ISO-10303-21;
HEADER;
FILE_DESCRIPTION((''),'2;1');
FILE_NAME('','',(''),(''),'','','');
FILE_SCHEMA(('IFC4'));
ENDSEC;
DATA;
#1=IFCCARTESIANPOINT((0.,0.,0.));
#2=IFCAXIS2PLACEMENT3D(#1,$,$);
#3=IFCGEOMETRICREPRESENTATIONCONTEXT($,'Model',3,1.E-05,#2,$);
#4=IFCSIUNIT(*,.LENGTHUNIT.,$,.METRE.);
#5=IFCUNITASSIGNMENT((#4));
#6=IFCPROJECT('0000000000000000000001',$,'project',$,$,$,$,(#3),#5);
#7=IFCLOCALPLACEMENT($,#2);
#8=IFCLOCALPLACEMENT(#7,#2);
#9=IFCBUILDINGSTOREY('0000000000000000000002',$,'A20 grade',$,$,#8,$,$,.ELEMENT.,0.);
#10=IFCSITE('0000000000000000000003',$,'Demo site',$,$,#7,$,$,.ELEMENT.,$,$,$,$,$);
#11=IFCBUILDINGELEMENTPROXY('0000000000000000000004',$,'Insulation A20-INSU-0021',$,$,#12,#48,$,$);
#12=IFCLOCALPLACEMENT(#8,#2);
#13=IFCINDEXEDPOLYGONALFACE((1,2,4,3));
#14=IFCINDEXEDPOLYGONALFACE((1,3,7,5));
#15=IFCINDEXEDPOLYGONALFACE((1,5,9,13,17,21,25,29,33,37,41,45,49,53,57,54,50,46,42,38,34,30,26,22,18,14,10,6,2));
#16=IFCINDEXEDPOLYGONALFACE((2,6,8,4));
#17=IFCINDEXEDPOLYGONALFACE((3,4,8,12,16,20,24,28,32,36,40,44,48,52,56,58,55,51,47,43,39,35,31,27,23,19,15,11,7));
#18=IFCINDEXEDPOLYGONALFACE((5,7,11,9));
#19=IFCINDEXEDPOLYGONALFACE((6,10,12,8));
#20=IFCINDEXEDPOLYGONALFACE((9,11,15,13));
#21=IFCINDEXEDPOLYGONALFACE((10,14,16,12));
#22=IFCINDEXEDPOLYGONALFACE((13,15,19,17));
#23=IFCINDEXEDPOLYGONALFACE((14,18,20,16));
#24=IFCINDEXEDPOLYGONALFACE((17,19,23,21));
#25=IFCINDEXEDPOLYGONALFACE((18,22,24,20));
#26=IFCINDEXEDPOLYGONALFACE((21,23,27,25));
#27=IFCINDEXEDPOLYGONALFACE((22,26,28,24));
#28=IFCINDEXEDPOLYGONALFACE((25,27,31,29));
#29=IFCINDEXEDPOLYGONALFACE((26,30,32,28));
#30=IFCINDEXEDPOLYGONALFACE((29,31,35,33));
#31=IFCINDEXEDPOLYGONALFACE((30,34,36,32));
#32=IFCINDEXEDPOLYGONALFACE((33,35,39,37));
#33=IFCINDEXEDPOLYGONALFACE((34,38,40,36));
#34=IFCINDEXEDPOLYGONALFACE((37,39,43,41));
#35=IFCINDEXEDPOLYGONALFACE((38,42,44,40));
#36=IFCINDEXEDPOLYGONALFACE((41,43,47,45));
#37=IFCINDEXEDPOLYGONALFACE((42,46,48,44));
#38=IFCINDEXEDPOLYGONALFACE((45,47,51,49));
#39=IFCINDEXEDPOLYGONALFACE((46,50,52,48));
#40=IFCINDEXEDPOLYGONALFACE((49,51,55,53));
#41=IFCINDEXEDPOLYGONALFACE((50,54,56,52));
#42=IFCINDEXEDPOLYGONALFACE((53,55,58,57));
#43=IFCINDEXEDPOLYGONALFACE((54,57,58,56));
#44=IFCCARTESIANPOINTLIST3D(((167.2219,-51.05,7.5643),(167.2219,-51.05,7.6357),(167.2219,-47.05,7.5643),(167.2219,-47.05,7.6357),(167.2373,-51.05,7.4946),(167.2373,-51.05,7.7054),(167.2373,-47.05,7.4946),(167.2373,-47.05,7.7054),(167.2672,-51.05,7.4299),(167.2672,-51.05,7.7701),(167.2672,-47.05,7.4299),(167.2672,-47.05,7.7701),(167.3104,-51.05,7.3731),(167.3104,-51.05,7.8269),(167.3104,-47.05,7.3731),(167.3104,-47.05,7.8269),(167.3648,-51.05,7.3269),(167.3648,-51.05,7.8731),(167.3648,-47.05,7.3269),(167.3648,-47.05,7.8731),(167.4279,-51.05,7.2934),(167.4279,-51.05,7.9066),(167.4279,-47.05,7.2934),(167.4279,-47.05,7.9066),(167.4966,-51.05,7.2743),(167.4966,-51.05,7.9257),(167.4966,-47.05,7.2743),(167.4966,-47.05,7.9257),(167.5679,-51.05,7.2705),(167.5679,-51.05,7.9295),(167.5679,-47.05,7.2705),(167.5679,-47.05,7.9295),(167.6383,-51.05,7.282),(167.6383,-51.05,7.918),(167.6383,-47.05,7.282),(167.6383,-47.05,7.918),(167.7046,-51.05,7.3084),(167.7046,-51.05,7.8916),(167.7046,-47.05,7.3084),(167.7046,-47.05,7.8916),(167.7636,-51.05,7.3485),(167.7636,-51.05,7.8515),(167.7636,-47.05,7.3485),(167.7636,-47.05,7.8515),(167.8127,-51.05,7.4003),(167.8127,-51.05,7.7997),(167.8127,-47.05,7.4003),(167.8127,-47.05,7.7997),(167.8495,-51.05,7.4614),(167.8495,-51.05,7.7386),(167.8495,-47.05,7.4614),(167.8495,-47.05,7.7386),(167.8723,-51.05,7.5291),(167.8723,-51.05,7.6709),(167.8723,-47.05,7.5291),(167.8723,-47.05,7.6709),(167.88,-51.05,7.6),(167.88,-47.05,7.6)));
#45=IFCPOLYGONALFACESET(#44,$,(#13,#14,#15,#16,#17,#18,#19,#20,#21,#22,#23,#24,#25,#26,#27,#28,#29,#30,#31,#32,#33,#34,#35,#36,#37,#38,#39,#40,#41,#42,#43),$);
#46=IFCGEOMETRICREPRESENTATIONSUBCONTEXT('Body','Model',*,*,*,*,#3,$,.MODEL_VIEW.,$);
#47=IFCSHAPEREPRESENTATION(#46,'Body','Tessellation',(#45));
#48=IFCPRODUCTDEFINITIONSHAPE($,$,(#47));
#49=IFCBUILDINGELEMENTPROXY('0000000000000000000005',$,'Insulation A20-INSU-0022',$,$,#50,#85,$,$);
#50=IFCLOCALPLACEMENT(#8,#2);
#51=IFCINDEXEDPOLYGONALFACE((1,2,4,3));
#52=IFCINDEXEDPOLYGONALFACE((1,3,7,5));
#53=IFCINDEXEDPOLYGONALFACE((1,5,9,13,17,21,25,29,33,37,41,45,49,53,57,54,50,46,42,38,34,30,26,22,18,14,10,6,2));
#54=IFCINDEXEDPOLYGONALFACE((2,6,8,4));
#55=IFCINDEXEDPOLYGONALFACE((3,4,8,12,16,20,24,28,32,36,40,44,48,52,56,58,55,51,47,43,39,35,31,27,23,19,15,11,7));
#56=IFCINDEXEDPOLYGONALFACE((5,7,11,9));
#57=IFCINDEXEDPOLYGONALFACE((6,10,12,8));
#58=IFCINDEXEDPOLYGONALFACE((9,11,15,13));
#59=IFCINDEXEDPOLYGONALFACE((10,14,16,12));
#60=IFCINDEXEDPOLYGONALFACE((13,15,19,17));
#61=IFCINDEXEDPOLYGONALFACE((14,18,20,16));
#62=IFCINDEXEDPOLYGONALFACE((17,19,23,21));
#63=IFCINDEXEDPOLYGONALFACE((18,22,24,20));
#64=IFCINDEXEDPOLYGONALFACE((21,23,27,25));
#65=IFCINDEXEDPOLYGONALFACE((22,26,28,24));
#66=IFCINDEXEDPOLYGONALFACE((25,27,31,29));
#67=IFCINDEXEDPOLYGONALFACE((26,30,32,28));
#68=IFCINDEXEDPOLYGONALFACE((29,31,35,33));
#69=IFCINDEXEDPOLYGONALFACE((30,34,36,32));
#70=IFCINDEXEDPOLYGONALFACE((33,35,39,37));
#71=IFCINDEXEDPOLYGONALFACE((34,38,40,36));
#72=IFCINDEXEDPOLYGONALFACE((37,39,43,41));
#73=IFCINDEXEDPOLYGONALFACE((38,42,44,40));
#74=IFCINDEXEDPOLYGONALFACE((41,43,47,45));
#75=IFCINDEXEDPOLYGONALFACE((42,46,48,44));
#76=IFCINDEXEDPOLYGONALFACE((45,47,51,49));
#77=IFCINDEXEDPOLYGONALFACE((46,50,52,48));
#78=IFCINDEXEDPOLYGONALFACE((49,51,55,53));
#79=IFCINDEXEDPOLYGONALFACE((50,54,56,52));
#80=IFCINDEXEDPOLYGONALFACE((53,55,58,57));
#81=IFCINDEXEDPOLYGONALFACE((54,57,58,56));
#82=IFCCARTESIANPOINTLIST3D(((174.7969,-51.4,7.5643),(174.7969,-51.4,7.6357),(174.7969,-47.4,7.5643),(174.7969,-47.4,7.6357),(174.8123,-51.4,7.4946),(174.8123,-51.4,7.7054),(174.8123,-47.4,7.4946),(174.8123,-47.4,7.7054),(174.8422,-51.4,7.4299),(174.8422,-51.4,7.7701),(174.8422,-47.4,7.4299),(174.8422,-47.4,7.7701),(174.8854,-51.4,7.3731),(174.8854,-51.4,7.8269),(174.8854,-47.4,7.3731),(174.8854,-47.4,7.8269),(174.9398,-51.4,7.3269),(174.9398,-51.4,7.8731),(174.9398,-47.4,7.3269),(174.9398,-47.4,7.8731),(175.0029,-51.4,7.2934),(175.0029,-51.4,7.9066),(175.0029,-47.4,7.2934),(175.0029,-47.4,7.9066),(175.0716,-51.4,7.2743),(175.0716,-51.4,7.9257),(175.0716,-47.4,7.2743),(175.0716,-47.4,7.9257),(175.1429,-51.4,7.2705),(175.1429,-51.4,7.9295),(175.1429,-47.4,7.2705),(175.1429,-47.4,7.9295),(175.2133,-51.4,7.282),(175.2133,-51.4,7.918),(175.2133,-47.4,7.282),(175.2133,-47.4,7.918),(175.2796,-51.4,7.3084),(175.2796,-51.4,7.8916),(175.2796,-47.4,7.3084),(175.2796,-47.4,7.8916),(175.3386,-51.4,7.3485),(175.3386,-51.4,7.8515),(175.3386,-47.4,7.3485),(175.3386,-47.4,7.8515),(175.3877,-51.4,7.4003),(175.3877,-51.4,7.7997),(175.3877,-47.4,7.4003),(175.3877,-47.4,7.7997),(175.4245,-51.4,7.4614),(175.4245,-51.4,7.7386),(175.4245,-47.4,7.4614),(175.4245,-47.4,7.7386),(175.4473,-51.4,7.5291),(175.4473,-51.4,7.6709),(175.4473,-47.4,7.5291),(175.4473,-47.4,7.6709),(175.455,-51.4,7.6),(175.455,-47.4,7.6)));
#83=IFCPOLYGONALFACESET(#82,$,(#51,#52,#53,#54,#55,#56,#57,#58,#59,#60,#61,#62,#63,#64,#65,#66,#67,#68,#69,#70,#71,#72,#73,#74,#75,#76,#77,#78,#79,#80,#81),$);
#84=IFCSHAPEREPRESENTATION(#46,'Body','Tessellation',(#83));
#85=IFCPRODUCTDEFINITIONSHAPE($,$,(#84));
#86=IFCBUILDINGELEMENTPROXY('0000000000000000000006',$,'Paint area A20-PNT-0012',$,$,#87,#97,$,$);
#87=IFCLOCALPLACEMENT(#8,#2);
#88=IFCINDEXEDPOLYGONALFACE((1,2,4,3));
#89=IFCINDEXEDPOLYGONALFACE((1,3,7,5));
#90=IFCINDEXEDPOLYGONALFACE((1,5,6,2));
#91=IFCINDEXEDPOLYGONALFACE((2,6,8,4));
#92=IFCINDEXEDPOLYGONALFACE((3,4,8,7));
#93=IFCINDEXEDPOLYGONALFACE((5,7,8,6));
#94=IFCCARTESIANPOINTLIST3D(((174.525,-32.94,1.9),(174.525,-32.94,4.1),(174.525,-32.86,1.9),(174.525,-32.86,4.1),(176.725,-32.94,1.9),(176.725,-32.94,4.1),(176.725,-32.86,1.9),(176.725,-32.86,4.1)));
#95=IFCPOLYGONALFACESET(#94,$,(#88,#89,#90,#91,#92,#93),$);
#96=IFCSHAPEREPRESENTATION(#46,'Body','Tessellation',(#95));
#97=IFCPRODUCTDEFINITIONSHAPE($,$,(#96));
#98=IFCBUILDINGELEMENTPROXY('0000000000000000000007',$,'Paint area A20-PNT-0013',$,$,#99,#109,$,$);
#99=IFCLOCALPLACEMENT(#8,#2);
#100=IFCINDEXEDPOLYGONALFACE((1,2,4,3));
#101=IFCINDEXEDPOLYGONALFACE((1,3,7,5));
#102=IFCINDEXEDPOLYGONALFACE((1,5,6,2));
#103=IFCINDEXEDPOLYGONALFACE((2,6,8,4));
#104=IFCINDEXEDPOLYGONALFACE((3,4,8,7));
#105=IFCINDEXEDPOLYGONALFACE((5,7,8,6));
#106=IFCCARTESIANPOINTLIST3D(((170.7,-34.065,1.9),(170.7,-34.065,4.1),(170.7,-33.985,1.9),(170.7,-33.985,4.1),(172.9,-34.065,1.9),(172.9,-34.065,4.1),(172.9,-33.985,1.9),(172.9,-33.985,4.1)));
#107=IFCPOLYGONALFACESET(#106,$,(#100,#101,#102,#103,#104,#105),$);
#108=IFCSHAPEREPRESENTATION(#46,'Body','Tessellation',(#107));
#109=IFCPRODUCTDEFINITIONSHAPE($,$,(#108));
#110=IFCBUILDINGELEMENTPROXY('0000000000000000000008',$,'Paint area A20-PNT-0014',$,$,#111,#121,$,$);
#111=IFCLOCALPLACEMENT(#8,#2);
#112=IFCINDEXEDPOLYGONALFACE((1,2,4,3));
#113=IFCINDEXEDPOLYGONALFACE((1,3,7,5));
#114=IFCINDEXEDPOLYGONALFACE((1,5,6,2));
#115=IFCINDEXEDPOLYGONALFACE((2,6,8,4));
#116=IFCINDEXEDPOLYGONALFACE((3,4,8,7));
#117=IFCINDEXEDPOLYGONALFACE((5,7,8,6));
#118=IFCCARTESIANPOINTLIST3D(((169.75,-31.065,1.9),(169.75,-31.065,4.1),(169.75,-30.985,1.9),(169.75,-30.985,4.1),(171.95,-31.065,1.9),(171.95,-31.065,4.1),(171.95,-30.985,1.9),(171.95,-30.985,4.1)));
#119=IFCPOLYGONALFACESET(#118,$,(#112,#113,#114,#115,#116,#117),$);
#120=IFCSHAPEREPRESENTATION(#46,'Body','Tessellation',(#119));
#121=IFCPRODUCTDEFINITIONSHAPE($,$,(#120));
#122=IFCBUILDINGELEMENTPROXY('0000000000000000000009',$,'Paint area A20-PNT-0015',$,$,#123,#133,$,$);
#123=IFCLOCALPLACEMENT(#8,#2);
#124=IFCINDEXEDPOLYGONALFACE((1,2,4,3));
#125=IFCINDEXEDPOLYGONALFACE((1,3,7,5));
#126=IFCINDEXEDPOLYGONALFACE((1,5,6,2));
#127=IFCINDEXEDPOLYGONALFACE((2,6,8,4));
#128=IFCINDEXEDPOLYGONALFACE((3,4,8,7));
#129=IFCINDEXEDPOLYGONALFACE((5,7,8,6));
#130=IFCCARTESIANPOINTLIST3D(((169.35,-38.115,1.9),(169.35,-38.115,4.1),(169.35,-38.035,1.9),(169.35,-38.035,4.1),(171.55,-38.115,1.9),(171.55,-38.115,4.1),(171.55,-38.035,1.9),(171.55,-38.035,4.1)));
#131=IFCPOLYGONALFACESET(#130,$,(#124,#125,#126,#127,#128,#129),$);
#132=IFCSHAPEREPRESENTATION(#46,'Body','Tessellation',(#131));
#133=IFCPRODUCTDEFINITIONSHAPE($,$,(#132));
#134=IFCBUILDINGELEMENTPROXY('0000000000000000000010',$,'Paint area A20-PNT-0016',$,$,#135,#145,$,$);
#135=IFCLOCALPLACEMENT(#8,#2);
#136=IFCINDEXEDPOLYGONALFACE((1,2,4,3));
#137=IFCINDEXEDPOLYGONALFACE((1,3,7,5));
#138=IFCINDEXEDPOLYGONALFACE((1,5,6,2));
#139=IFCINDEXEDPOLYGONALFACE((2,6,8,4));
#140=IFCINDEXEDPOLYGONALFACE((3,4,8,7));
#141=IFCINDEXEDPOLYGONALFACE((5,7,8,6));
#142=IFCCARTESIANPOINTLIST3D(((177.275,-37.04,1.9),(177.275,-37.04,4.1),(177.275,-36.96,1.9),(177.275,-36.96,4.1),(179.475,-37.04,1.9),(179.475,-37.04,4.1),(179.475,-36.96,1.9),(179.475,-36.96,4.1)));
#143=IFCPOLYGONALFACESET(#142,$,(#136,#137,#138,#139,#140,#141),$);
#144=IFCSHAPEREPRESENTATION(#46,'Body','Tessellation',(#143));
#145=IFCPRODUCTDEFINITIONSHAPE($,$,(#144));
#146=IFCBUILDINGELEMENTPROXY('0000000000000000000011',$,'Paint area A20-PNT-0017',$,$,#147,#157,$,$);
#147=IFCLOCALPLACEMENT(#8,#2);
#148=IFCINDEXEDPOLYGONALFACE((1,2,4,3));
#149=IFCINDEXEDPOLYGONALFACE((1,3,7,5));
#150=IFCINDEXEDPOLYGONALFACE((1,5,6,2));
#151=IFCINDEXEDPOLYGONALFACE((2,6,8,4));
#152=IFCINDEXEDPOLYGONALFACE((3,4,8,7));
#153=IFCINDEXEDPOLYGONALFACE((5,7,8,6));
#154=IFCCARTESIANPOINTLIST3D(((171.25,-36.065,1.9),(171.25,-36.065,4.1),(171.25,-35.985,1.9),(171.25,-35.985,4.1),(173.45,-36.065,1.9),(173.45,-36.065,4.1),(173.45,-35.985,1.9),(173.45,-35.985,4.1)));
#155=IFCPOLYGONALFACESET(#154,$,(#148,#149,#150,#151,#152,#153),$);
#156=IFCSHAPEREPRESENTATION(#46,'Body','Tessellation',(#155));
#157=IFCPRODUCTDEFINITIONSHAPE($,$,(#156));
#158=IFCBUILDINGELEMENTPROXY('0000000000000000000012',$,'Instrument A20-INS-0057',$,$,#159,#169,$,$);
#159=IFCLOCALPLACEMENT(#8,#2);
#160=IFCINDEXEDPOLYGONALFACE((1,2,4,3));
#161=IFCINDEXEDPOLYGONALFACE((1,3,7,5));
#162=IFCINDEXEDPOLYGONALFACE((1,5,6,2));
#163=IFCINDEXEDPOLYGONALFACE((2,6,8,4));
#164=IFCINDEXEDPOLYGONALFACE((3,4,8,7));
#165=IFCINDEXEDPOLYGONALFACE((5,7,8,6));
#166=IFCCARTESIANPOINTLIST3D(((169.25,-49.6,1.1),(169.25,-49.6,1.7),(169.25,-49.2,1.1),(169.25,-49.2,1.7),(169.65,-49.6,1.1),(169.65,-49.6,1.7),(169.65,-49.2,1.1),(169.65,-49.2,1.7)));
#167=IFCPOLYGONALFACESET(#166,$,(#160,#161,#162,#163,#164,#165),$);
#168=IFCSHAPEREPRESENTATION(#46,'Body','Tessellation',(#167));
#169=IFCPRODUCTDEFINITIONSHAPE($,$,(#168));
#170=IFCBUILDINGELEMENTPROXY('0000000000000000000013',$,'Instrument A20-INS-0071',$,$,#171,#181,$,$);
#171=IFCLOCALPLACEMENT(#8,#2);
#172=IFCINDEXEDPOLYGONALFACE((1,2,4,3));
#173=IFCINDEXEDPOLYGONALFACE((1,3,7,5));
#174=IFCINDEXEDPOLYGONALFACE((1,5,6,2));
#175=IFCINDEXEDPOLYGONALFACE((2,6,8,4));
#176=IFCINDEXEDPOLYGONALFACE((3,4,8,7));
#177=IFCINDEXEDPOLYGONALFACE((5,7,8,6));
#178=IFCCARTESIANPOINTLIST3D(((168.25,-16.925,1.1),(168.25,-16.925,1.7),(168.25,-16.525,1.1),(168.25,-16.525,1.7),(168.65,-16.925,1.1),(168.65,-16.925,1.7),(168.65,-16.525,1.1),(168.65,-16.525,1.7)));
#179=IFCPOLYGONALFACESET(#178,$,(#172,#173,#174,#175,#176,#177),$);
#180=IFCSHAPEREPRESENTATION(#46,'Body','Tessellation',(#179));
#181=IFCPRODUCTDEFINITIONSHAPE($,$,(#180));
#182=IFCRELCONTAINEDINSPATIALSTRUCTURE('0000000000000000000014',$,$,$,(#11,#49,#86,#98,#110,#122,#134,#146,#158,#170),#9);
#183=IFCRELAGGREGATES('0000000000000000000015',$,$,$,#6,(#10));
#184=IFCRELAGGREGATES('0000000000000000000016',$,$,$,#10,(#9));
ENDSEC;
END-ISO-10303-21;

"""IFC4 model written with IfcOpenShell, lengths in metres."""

from ifc_helpers import new_model, si_unit, frame, origin, place, context, subcontext, project, spatial, rectangle, circle, extrude, element, save


model = new_model("IFC4")

# Units and contexts
model_context = context("Model", 3, precision=1e-05, world=origin())
body_context = subcontext(model_context, "Body", "Model", "MODEL_VIEW")
ifc_project = project(units=[si_unit("LENGTHUNIT", "METRE")], contexts=[model_context])

# Site, storey
site_placement = place(None, origin())
site = spatial("IfcSite", under=ifc_project, at=site_placement, Name="Demo site", CompositionType="ELEMENT")
storey_placement = place(site_placement, origin())
storey = spatial("IfcBuildingStorey", under=site, at=storey_placement, Name="A20 grade", CompositionType="ELEMENT", Elevation=0.0)

# Building element proxies
for number, where, name in (
    (1, (167.55, -51.05, 7.6), "Insulation A20-INSU-0021"),
    (2, (175.125, -51.4, 7.6), "Insulation A20-INSU-0022"),
):
    element("IfcBuildingElementProxy", number, at=place(storey_placement, frame(where)), inside=storey, Name=name, context=body_context, shape_type="SweptSolid", body=[
        extrude(circle(Radius=0.33), frame((0.0, 0.0, 0.0), z_axis=(0.0, 1.0, 0.0), x_axis=(1.0, 0.0, 0.0)), (0.0, 0.0, 1.0), 4.0),
    ])
for number, where, name in (
    (3, (175.625, -32.9, 1.9), "Paint area A20-PNT-0012"),
    (4, (171.8, -34.025, 1.9), "Paint area A20-PNT-0013"),
    (5, (170.85, -31.025, 1.9), "Paint area A20-PNT-0014"),
    (6, (170.45, -38.075, 1.9), "Paint area A20-PNT-0015"),
    (7, (178.375, -37.0, 1.9), "Paint area A20-PNT-0016"),
    (8, (172.35, -36.025, 1.9), "Paint area A20-PNT-0017"),
):
    element("IfcBuildingElementProxy", number, at=place(storey_placement, frame(where)), inside=storey, Name=name, context=body_context, shape_type="SweptSolid", body=[
        extrude(rectangle(XDim=2.2, YDim=0.08), origin(), (0.0, 0.0, 1.0), 2.2),
    ])
for number, where, name in (
    (9, (169.45, -49.4, 1.1), "Instrument A20-INS-0057"),
    (10, (168.45, -16.725, 1.1), "Instrument A20-INS-0071"),
):
    element("IfcBuildingElementProxy", number, at=place(storey_placement, frame(where)), inside=storey, Name=name, context=body_context, shape_type="SweptSolid", body=[
        extrude(rectangle(XDim=0.4, YDim=0.4), origin(), (0.0, 0.0, 1.0), 0.6),
    ])

save(model, "model.ifc")
